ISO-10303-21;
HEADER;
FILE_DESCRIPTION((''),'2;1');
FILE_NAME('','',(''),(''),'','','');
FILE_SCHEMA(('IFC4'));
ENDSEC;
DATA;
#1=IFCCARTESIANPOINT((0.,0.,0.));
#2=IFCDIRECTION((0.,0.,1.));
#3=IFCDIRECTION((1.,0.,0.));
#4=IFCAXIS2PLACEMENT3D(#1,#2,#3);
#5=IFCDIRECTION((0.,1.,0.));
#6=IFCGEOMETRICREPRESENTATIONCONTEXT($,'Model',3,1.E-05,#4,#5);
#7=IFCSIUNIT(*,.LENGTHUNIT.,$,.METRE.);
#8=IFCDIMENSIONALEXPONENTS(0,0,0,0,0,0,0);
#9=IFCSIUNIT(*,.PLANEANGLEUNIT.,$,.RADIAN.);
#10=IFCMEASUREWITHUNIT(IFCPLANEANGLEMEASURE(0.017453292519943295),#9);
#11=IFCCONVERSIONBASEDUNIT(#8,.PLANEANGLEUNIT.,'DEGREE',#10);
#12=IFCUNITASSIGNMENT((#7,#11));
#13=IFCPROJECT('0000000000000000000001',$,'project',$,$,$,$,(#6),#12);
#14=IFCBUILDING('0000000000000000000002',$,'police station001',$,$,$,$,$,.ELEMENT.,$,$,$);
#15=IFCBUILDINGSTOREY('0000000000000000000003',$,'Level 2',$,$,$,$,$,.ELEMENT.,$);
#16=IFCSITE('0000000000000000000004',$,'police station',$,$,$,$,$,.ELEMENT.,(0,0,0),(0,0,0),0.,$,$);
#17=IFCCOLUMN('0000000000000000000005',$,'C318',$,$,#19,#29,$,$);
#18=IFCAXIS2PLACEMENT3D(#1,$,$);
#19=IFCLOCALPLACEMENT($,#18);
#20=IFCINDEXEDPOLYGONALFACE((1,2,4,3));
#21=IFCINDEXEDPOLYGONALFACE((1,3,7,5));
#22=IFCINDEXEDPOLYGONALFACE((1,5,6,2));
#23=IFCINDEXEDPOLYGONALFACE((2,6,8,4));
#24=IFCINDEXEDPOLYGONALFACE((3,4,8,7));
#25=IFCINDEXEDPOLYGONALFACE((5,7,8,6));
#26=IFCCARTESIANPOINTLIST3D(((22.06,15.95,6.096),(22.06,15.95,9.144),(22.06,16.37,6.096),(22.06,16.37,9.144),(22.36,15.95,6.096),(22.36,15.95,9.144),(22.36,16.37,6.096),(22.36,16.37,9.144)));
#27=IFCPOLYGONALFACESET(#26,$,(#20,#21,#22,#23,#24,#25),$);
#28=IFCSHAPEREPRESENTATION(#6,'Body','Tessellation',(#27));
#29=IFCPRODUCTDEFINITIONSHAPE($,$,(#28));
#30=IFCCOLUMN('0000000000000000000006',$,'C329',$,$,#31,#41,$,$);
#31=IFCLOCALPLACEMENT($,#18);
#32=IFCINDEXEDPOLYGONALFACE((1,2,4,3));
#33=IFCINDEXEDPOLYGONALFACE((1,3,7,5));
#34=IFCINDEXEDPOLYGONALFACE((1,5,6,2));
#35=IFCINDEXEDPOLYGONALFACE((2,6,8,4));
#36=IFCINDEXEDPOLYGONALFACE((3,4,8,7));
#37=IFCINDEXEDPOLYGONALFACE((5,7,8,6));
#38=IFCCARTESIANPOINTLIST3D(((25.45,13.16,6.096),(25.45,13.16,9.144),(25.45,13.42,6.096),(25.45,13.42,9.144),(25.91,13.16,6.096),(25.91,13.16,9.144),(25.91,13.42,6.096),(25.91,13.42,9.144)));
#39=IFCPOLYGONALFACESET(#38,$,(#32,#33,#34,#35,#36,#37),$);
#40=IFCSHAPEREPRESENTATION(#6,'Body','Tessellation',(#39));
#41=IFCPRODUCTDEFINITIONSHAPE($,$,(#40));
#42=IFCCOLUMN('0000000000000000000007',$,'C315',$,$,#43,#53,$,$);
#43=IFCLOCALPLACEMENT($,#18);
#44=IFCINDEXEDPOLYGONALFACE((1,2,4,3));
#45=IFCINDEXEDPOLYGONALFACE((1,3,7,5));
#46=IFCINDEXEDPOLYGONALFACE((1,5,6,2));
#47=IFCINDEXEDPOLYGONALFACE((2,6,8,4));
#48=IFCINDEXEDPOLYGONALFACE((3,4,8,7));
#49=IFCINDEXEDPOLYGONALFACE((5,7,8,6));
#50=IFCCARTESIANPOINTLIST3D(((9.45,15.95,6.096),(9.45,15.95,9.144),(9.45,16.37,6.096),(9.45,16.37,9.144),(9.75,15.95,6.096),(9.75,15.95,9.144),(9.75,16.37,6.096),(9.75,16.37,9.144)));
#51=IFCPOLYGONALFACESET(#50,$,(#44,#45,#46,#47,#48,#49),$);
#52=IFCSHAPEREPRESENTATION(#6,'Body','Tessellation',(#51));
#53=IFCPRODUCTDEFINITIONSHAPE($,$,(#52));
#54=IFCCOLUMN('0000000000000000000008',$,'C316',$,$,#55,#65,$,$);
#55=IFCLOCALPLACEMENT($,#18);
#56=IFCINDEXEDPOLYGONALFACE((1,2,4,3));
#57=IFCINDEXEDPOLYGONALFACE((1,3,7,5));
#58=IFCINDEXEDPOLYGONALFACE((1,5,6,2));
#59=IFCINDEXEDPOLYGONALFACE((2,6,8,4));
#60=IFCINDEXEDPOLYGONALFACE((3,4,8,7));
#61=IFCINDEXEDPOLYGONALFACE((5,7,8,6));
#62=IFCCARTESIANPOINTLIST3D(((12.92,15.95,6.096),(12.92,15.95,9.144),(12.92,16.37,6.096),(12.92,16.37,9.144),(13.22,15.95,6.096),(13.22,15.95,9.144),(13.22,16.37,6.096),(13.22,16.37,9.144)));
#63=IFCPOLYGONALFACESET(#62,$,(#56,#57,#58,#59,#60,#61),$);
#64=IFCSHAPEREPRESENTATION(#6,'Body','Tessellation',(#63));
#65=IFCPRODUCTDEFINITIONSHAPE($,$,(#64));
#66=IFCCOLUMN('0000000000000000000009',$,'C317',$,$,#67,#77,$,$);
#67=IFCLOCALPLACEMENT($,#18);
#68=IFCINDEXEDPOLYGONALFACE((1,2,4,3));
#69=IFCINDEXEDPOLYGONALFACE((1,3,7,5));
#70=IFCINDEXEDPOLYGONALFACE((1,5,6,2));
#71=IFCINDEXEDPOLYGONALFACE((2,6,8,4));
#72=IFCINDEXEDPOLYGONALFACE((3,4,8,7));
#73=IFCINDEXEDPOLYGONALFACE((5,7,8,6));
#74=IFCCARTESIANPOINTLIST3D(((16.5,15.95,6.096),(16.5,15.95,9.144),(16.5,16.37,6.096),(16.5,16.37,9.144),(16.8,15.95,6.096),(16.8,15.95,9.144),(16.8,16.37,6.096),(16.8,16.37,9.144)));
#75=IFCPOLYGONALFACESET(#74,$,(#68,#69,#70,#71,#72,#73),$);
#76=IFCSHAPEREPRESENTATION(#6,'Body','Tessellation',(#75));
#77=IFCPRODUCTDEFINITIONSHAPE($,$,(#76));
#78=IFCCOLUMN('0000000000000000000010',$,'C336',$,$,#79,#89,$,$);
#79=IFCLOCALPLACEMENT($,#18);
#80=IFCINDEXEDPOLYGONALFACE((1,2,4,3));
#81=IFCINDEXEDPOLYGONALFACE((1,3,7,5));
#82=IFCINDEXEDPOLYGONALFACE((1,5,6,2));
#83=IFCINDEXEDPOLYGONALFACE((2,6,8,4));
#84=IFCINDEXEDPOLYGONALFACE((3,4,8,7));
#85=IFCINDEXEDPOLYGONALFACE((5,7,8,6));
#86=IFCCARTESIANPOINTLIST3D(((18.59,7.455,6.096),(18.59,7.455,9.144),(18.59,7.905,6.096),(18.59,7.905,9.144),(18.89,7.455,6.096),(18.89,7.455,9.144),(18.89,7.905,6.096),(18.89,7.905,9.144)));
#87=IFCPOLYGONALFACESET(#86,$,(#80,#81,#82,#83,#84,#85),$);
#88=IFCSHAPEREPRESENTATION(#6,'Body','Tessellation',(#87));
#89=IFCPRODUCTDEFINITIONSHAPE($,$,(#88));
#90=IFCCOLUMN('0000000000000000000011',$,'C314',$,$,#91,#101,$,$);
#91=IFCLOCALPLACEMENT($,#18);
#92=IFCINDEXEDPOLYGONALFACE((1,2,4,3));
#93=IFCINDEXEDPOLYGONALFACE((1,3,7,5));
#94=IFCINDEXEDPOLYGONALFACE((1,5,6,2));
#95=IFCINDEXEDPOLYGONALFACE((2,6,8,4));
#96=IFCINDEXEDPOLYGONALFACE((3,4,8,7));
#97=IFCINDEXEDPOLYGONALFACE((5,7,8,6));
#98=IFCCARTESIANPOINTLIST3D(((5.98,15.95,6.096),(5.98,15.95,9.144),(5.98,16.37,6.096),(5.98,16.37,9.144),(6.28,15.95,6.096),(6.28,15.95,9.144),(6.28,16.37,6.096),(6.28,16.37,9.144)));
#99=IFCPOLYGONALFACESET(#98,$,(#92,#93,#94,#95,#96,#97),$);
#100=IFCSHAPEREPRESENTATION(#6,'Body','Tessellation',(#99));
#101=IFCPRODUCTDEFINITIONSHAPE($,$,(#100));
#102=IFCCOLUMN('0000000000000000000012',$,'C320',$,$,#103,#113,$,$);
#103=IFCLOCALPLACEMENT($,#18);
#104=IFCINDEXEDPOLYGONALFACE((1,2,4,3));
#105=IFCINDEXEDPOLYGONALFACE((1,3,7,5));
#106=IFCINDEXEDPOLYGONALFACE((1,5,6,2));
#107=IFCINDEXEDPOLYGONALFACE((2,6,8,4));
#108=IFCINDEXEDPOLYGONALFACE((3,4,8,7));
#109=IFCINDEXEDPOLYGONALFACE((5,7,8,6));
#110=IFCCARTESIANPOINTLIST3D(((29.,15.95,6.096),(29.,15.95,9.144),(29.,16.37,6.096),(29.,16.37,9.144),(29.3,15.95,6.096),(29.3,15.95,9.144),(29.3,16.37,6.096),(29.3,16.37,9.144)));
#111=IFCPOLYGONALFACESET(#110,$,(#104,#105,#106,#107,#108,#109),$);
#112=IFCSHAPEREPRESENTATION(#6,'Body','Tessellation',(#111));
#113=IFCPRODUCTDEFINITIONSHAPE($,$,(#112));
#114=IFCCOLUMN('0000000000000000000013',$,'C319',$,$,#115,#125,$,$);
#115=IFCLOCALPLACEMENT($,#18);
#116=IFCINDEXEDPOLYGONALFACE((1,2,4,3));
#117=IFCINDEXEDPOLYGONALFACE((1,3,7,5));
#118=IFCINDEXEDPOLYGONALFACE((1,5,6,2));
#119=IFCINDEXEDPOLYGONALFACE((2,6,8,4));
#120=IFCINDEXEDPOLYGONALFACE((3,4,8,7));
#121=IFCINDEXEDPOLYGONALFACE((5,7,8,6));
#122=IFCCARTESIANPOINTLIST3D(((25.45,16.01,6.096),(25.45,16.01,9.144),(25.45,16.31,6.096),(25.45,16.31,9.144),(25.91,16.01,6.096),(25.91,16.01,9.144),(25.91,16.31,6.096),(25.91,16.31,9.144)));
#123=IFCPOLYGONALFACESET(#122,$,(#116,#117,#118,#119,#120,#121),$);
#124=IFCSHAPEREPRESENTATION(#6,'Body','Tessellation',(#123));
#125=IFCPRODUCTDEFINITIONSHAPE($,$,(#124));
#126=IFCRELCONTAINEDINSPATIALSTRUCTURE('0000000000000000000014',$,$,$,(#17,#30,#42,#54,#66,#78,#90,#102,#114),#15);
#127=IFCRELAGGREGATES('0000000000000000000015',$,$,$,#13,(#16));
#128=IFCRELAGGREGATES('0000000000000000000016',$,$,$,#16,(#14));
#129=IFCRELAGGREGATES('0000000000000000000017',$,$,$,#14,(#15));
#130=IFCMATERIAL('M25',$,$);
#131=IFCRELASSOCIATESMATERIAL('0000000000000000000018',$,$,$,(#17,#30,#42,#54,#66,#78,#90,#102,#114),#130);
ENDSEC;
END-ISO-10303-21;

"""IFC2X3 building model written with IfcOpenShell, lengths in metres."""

from ifc_helpers import new_model, entity, si_unit, converted_unit, direction, frame, frame_2d, origin_with_axes, place, context, project, spatial, rectangle, extrude, material, element, save


model = new_model("IFC2X3")

# Units and contexts
model_context = context("Model", 3, precision=1e-05, world=origin_with_axes(), true_north=direction((0.0, 1.0, 0.0)))
ifc_project = project(units=[si_unit("LENGTHUNIT", "METRE"), converted_unit("PLANEANGLEUNIT", "DEGREE", entity("IfcPlaneAngleMeasure", 0.017453292519943295), si_unit("PLANEANGLEUNIT", "RADIAN"), dimensions=[0, 0, 0, 0, 0, 0, 0])], contexts=[model_context])

# Site, building, storey
site = spatial("IfcSite", under=ifc_project, Name="police station", CompositionType="ELEMENT", RefLatitude=(0, 0, 0), RefLongitude=(0, 0, 0), RefElevation=0.0)
building = spatial("IfcBuilding", under=site, Name="police station001", CompositionType="ELEMENT")
storey = spatial("IfcBuildingStorey", under=building, Name="Level 2", CompositionType="ELEMENT")

# Columns
ifc_material = material(Name="M25")
placement = place(None, origin_with_axes())
element("IfcColumn", 1, at=placement, inside=storey, material=ifc_material, Name="C318", context=model_context, shape_type="SweptSolid", body=[
    extrude(rectangle(XDim=0.3, YDim=0.42, at=frame_2d((0.0, 0.0), x_axis=(1.0, 0.0, 0.0))), frame((22.21, 16.16, 6.096), z_axis=(0.0, 0.0, 1.0), x_axis=(1.0, 0.0, 0.0)), (0.0, 0.0, 1.0), 3.048),
])
element("IfcColumn", 2, at=placement, inside=storey, material=ifc_material, Name="C329", context=model_context, shape_type="SweptSolid", body=[
    extrude(rectangle(XDim=0.46, YDim=0.26, at=frame_2d((0.0, 0.0), x_axis=(1.0, 0.0, 0.0))), frame((25.68, 13.29, 6.096), z_axis=(0.0, 0.0, 1.0), x_axis=(1.0, 0.0, 0.0)), (0.0, 0.0, 1.0), 3.048),
])
element("IfcColumn", 3, at=placement, inside=storey, material=ifc_material, Name="C315", context=model_context, shape_type="SweptSolid", body=[
    extrude(rectangle(XDim=0.3, YDim=0.42, at=frame_2d((0.0, 0.0), x_axis=(1.0, 0.0, 0.0))), frame((9.6, 16.16, 6.096), z_axis=(0.0, 0.0, 1.0), x_axis=(1.0, 0.0, 0.0)), (0.0, 0.0, 1.0), 3.048),
])
element("IfcColumn", 4, at=placement, inside=storey, material=ifc_material, Name="C316", context=model_context, shape_type="SweptSolid", body=[
    extrude(rectangle(XDim=0.3, YDim=0.42, at=frame_2d((0.0, 0.0), x_axis=(1.0, 0.0, 0.0))), frame((13.07, 16.16, 6.096), z_axis=(0.0, 0.0, 1.0), x_axis=(1.0, 0.0, 0.0)), (0.0, 0.0, 1.0), 3.048),
])
element("IfcColumn", 5, at=placement, inside=storey, material=ifc_material, Name="C317", context=model_context, shape_type="SweptSolid", body=[
    extrude(rectangle(XDim=0.3, YDim=0.42, at=frame_2d((0.0, 0.0), x_axis=(1.0, 0.0, 0.0))), frame((16.65, 16.16, 6.096), z_axis=(0.0, 0.0, 1.0), x_axis=(1.0, 0.0, 0.0)), (0.0, 0.0, 1.0), 3.048),
])
element("IfcColumn", 6, at=placement, inside=storey, material=ifc_material, Name="C336", context=model_context, shape_type="SweptSolid", body=[
    extrude(rectangle(XDim=0.3, YDim=0.45, at=frame_2d((0.0, 0.0), x_axis=(1.0, 0.0, 0.0))), frame((18.74, 7.68, 6.096), z_axis=(0.0, 0.0, 1.0), x_axis=(1.0, 0.0, 0.0)), (0.0, 0.0, 1.0), 3.048),
])
element("IfcColumn", 7, at=placement, inside=storey, material=ifc_material, Name="C314", context=model_context, shape_type="SweptSolid", body=[
    extrude(rectangle(XDim=0.3, YDim=0.42, at=frame_2d((0.0, 0.0), x_axis=(1.0, 0.0, 0.0))), frame((6.13, 16.16, 6.096), z_axis=(0.0, 0.0, 1.0), x_axis=(1.0, 0.0, 0.0)), (0.0, 0.0, 1.0), 3.048),
])
element("IfcColumn", 8, at=placement, inside=storey, material=ifc_material, Name="C320", context=model_context, shape_type="SweptSolid", body=[
    extrude(rectangle(XDim=0.3, YDim=0.42, at=frame_2d((0.0, 0.0), x_axis=(1.0, 0.0, 0.0))), frame((29.15, 16.16, 6.096), z_axis=(0.0, 0.0, 1.0), x_axis=(1.0, 0.0, 0.0)), (0.0, 0.0, 1.0), 3.048),
])
element("IfcColumn", 9, at=placement, inside=storey, material=ifc_material, Name="C319", context=model_context, shape_type="SweptSolid", body=[
    extrude(rectangle(XDim=0.46, YDim=0.3, at=frame_2d((0.0, 0.0), x_axis=(1.0, 0.0, 0.0))), frame((25.68, 16.16, 6.096), z_axis=(0.0, 0.0, 1.0), x_axis=(1.0, 0.0, 0.0)), (0.0, 0.0, 1.0), 3.048),
])

save(model, "model.ifc")
